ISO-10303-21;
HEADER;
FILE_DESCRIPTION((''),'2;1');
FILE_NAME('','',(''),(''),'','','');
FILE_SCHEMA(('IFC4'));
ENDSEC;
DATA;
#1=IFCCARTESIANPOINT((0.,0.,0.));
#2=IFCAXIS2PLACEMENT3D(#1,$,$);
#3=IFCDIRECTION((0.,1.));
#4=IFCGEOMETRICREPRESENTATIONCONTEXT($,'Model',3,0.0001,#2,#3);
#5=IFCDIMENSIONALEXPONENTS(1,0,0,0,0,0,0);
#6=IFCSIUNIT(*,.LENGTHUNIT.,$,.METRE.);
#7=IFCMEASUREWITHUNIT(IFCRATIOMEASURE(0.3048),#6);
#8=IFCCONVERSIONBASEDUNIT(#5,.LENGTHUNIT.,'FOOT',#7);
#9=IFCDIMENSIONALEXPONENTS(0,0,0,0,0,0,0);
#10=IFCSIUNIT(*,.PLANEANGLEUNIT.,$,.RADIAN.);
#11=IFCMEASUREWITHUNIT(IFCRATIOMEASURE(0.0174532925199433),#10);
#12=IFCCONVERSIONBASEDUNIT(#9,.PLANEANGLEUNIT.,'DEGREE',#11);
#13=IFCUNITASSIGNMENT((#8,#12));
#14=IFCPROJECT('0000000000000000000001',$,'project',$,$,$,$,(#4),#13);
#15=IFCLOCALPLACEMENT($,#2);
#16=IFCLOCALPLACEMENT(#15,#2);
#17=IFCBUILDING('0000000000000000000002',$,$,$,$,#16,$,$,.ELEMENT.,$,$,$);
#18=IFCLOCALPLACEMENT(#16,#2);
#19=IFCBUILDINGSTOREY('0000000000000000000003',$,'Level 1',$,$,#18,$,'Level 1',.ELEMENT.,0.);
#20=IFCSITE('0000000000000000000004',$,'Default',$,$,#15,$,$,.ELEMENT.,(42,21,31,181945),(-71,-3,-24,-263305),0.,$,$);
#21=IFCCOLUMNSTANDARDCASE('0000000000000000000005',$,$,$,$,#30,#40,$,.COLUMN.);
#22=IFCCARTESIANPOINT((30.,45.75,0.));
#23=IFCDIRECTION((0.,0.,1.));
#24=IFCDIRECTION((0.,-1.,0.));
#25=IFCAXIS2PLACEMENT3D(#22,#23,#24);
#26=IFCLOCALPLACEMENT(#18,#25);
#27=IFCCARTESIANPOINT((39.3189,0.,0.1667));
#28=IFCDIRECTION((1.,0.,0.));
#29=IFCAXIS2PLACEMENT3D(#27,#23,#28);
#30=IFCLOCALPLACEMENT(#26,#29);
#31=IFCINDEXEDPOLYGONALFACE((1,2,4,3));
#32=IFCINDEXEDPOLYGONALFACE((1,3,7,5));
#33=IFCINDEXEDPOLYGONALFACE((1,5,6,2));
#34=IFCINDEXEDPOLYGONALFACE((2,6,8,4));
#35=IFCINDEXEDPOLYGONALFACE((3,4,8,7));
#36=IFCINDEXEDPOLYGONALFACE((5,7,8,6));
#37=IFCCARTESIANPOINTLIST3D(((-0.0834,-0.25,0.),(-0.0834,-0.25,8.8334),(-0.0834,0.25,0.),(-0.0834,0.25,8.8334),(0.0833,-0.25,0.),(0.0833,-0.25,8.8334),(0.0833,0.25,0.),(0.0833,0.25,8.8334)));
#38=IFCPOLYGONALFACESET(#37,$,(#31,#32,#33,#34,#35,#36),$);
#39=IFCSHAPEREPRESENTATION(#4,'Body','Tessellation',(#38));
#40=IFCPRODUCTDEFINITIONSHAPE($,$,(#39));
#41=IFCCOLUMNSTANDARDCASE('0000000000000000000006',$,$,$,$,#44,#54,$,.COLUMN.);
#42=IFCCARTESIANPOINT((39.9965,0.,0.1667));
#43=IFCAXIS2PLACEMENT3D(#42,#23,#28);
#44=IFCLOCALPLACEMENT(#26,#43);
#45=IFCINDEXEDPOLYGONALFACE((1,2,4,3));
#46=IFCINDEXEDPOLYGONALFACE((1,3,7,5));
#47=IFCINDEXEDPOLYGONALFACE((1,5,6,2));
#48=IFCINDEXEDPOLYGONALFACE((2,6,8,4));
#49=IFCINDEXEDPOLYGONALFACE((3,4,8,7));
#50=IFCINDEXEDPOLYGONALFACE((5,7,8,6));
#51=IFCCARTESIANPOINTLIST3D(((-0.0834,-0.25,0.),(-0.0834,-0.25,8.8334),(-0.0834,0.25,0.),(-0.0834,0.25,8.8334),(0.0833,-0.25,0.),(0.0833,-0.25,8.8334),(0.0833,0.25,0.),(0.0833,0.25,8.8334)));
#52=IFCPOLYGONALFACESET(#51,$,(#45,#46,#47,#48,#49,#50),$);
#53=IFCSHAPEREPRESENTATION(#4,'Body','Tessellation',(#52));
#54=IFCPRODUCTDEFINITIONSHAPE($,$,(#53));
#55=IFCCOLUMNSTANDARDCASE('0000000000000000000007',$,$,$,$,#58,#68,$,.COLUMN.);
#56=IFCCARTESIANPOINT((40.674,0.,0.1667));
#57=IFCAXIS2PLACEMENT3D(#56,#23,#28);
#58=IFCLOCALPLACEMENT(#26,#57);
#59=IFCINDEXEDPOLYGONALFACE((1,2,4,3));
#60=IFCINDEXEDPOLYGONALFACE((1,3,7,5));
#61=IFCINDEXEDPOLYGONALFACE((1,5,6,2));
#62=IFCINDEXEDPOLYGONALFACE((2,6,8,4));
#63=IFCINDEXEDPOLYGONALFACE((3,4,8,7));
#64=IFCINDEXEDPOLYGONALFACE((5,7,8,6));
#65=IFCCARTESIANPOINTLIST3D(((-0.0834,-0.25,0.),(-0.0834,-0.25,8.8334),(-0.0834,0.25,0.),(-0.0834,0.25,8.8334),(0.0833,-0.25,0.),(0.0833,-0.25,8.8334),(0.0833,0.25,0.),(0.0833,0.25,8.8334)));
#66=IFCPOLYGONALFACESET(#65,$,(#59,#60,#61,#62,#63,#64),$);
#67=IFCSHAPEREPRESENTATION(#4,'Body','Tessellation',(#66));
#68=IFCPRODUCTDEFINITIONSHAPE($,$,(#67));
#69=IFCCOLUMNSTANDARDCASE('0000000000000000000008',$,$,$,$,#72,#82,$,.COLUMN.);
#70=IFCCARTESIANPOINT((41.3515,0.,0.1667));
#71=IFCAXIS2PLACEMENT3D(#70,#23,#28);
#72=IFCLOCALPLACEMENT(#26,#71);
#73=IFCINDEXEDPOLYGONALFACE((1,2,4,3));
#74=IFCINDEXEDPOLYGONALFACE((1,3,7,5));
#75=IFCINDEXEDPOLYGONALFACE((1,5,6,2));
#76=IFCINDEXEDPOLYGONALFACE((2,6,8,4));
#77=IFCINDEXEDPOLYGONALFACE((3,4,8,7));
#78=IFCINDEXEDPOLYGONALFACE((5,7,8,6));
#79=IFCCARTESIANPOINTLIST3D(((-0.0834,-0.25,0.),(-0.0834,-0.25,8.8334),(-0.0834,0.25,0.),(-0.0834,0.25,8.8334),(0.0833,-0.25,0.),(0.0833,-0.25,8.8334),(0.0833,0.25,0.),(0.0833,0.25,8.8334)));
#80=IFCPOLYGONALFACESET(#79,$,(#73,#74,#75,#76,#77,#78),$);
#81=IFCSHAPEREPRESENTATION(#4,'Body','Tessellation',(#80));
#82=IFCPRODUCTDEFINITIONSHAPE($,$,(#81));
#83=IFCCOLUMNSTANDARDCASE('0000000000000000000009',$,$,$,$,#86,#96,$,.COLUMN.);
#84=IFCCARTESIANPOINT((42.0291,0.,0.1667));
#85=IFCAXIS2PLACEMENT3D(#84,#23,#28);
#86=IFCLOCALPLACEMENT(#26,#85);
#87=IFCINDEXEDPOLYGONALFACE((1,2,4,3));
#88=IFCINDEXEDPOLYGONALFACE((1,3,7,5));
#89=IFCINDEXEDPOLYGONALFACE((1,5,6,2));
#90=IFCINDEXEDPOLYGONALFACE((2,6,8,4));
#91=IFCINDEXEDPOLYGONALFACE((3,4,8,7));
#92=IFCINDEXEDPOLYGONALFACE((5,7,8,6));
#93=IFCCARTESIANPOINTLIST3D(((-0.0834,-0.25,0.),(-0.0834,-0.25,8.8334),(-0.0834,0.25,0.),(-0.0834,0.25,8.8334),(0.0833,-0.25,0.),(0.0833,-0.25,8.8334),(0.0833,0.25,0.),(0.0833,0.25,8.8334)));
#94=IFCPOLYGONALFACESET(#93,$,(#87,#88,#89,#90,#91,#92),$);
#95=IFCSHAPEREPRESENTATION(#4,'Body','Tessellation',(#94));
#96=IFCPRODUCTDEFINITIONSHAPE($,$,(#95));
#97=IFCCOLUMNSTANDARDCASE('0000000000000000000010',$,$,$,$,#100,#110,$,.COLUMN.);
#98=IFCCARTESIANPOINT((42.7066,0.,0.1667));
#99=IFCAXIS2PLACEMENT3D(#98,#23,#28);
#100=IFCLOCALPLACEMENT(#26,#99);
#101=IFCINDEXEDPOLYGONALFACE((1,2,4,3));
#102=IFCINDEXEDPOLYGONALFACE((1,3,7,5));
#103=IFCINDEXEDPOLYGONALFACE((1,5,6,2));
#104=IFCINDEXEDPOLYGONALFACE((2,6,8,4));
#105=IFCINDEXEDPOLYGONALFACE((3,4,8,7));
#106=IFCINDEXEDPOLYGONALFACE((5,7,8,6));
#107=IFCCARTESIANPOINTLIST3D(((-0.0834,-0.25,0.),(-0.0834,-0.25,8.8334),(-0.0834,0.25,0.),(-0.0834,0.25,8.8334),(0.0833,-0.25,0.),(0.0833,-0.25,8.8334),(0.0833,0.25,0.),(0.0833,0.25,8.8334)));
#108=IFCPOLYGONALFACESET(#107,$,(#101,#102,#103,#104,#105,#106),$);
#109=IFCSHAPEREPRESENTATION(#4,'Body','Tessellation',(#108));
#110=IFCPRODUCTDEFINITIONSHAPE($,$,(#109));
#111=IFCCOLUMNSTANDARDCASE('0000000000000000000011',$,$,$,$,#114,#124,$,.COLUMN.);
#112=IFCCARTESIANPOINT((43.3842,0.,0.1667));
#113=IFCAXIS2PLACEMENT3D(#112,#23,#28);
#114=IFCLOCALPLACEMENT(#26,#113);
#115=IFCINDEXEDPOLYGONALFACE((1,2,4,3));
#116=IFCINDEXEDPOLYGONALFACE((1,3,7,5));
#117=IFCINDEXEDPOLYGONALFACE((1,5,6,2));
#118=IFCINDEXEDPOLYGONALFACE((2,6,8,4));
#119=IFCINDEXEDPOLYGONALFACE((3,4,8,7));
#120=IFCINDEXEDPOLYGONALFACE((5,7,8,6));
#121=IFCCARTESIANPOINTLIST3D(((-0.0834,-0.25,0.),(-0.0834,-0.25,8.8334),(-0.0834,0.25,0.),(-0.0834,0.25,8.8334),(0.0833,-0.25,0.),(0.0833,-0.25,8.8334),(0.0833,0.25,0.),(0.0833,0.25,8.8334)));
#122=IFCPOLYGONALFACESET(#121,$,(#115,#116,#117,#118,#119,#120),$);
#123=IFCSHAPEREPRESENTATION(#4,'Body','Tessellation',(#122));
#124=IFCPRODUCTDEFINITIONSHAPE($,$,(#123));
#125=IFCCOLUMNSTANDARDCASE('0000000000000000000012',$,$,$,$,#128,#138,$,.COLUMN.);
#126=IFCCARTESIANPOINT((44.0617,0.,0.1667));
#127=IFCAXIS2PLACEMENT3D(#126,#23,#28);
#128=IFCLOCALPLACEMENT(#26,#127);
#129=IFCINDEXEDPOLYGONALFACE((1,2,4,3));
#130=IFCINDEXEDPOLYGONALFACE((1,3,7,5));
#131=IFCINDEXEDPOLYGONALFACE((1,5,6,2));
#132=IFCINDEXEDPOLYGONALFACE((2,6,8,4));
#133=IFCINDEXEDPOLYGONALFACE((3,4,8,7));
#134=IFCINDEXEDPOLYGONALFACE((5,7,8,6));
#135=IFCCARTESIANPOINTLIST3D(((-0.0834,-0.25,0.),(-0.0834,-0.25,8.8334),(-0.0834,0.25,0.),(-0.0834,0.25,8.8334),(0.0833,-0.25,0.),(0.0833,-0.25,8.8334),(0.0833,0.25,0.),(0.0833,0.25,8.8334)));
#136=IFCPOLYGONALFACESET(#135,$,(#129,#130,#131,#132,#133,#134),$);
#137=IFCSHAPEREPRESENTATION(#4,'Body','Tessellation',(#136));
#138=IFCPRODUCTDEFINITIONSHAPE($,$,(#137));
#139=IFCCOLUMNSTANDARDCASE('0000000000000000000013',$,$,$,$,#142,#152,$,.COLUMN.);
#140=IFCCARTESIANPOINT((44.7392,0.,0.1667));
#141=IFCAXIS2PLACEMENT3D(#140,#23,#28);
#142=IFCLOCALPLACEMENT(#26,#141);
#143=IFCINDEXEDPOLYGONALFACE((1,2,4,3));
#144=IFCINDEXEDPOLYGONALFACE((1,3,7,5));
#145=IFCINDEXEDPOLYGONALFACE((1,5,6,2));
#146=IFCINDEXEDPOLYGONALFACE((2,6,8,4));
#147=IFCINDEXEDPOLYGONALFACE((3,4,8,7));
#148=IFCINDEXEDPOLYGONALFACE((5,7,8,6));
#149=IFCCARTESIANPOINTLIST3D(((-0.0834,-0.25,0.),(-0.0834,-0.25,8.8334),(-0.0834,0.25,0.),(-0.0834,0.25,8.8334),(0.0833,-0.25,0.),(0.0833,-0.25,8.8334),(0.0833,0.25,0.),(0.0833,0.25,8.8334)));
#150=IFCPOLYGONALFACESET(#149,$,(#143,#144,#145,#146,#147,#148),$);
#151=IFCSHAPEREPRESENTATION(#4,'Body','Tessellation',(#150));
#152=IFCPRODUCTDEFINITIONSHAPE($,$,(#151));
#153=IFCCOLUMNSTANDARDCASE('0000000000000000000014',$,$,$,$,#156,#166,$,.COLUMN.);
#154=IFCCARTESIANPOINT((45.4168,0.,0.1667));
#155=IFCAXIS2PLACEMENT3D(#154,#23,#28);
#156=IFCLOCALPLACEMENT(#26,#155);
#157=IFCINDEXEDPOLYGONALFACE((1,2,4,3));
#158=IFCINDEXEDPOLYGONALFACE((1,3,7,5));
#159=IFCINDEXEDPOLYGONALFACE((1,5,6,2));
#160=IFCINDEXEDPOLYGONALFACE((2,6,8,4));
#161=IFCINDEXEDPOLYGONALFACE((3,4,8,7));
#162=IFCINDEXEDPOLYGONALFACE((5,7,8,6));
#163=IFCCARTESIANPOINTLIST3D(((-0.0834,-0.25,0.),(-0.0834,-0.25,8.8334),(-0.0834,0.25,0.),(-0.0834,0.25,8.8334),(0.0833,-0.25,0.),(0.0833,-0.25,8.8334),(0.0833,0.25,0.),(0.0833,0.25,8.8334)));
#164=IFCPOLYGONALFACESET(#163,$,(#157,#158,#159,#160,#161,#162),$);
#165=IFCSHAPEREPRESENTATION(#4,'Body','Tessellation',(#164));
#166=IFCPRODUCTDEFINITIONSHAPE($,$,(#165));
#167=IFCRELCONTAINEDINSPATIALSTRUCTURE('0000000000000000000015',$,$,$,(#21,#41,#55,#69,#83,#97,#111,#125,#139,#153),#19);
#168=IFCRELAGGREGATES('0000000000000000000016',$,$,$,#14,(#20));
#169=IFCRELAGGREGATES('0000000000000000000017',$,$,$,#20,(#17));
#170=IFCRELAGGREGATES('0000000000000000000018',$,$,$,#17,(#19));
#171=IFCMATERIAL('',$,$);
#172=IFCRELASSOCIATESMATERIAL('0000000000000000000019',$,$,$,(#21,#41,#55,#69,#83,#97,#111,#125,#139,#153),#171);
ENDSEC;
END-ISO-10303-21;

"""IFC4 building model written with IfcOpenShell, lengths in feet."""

from ifc_helpers import new_model, entity, si_unit, converted_unit, direction, frame, origin, place, context, project, spatial, rectangle, extrude, material, element, save


model = new_model("IFC4")

# Units and contexts
model_context = context("Model", 3, precision=0.0001, world=origin(), true_north=direction((0.0, 1.0)))
ifc_project = project(units=[converted_unit("LENGTHUNIT", "FOOT", entity("IfcRatioMeasure", 0.3048), si_unit("LENGTHUNIT", "METRE"), dimensions=[1, 0, 0, 0, 0, 0, 0]), converted_unit("PLANEANGLEUNIT", "DEGREE", entity("IfcRatioMeasure", 0.0174532925199433), si_unit("PLANEANGLEUNIT", "RADIAN"), dimensions=[0, 0, 0, 0, 0, 0, 0])], contexts=[model_context])

# Site, building, storey
site_placement = place(None, origin())
site = spatial("IfcSite", under=ifc_project, at=site_placement, Name="Default", CompositionType="ELEMENT", RefLatitude=(42, 21, 31, 181945), RefLongitude=(-71, -3, -24, -263305), RefElevation=0.0)
building_placement = place(site_placement, origin())
building = spatial("IfcBuilding", under=site, at=building_placement, CompositionType="ELEMENT")
storey_placement = place(building_placement, origin())
storey = spatial("IfcBuildingStorey", under=building, at=storey_placement, Name="Level 1", LongName="Level 1", CompositionType="ELEMENT", Elevation=0.0)

# Columns
ifc_material_1 = material(Name="")
placement_1 = place(storey_placement, frame((30.0, 45.75, 0.0), z_axis=(0.0, 0.0, 1.0), x_axis=(0.0, -1.0, 0.0)))
for number, where, z_axis, x_axis in (
    (1, (39.3189, 0.0, 0.1667), (0.0, 0.0, 1.0), (1.0, 0.0, 0.0)),
    (2, (39.9965, 0.0, 0.1667), (0.0, 0.0, 1.0), (1.0, 0.0, 0.0)),
    (3, (40.674, 0.0, 0.1667), (0.0, 0.0, 1.0), (1.0, 0.0, 0.0)),
    (4, (41.3515, 0.0, 0.1667), (0.0, 0.0, 1.0), (1.0, 0.0, 0.0)),
    (5, (42.0291, 0.0, 0.1667), (0.0, 0.0, 1.0), (1.0, 0.0, 0.0)),
    (6, (42.7066, 0.0, 0.1667), (0.0, 0.0, 1.0), (1.0, 0.0, 0.0)),
    (7, (43.3842, 0.0, 0.1667), (0.0, 0.0, 1.0), (1.0, 0.0, 0.0)),
    (8, (44.0617, 0.0, 0.1667), (0.0, 0.0, 1.0), (1.0, 0.0, 0.0)),
    (9, (44.7392, 0.0, 0.1667), (0.0, 0.0, 1.0), (1.0, 0.0, 0.0)),
    (10, (45.4168, 0.0, 0.1667), (0.0, 0.0, 1.0), (1.0, 0.0, 0.0)),
):
    element("IfcColumnStandardCase", number, at=place(placement_1, frame(where, z_axis=z_axis, x_axis=x_axis)), inside=storey, material=ifc_material_1, PredefinedType="COLUMN", context=model_context, shape_type="SweptSolid", body=[
        extrude(rectangle(XDim=0.1667, YDim=0.5), origin(), (0.0, 0.0, 1.0), 8.8334),
    ])

save(model, "model.ifc")
